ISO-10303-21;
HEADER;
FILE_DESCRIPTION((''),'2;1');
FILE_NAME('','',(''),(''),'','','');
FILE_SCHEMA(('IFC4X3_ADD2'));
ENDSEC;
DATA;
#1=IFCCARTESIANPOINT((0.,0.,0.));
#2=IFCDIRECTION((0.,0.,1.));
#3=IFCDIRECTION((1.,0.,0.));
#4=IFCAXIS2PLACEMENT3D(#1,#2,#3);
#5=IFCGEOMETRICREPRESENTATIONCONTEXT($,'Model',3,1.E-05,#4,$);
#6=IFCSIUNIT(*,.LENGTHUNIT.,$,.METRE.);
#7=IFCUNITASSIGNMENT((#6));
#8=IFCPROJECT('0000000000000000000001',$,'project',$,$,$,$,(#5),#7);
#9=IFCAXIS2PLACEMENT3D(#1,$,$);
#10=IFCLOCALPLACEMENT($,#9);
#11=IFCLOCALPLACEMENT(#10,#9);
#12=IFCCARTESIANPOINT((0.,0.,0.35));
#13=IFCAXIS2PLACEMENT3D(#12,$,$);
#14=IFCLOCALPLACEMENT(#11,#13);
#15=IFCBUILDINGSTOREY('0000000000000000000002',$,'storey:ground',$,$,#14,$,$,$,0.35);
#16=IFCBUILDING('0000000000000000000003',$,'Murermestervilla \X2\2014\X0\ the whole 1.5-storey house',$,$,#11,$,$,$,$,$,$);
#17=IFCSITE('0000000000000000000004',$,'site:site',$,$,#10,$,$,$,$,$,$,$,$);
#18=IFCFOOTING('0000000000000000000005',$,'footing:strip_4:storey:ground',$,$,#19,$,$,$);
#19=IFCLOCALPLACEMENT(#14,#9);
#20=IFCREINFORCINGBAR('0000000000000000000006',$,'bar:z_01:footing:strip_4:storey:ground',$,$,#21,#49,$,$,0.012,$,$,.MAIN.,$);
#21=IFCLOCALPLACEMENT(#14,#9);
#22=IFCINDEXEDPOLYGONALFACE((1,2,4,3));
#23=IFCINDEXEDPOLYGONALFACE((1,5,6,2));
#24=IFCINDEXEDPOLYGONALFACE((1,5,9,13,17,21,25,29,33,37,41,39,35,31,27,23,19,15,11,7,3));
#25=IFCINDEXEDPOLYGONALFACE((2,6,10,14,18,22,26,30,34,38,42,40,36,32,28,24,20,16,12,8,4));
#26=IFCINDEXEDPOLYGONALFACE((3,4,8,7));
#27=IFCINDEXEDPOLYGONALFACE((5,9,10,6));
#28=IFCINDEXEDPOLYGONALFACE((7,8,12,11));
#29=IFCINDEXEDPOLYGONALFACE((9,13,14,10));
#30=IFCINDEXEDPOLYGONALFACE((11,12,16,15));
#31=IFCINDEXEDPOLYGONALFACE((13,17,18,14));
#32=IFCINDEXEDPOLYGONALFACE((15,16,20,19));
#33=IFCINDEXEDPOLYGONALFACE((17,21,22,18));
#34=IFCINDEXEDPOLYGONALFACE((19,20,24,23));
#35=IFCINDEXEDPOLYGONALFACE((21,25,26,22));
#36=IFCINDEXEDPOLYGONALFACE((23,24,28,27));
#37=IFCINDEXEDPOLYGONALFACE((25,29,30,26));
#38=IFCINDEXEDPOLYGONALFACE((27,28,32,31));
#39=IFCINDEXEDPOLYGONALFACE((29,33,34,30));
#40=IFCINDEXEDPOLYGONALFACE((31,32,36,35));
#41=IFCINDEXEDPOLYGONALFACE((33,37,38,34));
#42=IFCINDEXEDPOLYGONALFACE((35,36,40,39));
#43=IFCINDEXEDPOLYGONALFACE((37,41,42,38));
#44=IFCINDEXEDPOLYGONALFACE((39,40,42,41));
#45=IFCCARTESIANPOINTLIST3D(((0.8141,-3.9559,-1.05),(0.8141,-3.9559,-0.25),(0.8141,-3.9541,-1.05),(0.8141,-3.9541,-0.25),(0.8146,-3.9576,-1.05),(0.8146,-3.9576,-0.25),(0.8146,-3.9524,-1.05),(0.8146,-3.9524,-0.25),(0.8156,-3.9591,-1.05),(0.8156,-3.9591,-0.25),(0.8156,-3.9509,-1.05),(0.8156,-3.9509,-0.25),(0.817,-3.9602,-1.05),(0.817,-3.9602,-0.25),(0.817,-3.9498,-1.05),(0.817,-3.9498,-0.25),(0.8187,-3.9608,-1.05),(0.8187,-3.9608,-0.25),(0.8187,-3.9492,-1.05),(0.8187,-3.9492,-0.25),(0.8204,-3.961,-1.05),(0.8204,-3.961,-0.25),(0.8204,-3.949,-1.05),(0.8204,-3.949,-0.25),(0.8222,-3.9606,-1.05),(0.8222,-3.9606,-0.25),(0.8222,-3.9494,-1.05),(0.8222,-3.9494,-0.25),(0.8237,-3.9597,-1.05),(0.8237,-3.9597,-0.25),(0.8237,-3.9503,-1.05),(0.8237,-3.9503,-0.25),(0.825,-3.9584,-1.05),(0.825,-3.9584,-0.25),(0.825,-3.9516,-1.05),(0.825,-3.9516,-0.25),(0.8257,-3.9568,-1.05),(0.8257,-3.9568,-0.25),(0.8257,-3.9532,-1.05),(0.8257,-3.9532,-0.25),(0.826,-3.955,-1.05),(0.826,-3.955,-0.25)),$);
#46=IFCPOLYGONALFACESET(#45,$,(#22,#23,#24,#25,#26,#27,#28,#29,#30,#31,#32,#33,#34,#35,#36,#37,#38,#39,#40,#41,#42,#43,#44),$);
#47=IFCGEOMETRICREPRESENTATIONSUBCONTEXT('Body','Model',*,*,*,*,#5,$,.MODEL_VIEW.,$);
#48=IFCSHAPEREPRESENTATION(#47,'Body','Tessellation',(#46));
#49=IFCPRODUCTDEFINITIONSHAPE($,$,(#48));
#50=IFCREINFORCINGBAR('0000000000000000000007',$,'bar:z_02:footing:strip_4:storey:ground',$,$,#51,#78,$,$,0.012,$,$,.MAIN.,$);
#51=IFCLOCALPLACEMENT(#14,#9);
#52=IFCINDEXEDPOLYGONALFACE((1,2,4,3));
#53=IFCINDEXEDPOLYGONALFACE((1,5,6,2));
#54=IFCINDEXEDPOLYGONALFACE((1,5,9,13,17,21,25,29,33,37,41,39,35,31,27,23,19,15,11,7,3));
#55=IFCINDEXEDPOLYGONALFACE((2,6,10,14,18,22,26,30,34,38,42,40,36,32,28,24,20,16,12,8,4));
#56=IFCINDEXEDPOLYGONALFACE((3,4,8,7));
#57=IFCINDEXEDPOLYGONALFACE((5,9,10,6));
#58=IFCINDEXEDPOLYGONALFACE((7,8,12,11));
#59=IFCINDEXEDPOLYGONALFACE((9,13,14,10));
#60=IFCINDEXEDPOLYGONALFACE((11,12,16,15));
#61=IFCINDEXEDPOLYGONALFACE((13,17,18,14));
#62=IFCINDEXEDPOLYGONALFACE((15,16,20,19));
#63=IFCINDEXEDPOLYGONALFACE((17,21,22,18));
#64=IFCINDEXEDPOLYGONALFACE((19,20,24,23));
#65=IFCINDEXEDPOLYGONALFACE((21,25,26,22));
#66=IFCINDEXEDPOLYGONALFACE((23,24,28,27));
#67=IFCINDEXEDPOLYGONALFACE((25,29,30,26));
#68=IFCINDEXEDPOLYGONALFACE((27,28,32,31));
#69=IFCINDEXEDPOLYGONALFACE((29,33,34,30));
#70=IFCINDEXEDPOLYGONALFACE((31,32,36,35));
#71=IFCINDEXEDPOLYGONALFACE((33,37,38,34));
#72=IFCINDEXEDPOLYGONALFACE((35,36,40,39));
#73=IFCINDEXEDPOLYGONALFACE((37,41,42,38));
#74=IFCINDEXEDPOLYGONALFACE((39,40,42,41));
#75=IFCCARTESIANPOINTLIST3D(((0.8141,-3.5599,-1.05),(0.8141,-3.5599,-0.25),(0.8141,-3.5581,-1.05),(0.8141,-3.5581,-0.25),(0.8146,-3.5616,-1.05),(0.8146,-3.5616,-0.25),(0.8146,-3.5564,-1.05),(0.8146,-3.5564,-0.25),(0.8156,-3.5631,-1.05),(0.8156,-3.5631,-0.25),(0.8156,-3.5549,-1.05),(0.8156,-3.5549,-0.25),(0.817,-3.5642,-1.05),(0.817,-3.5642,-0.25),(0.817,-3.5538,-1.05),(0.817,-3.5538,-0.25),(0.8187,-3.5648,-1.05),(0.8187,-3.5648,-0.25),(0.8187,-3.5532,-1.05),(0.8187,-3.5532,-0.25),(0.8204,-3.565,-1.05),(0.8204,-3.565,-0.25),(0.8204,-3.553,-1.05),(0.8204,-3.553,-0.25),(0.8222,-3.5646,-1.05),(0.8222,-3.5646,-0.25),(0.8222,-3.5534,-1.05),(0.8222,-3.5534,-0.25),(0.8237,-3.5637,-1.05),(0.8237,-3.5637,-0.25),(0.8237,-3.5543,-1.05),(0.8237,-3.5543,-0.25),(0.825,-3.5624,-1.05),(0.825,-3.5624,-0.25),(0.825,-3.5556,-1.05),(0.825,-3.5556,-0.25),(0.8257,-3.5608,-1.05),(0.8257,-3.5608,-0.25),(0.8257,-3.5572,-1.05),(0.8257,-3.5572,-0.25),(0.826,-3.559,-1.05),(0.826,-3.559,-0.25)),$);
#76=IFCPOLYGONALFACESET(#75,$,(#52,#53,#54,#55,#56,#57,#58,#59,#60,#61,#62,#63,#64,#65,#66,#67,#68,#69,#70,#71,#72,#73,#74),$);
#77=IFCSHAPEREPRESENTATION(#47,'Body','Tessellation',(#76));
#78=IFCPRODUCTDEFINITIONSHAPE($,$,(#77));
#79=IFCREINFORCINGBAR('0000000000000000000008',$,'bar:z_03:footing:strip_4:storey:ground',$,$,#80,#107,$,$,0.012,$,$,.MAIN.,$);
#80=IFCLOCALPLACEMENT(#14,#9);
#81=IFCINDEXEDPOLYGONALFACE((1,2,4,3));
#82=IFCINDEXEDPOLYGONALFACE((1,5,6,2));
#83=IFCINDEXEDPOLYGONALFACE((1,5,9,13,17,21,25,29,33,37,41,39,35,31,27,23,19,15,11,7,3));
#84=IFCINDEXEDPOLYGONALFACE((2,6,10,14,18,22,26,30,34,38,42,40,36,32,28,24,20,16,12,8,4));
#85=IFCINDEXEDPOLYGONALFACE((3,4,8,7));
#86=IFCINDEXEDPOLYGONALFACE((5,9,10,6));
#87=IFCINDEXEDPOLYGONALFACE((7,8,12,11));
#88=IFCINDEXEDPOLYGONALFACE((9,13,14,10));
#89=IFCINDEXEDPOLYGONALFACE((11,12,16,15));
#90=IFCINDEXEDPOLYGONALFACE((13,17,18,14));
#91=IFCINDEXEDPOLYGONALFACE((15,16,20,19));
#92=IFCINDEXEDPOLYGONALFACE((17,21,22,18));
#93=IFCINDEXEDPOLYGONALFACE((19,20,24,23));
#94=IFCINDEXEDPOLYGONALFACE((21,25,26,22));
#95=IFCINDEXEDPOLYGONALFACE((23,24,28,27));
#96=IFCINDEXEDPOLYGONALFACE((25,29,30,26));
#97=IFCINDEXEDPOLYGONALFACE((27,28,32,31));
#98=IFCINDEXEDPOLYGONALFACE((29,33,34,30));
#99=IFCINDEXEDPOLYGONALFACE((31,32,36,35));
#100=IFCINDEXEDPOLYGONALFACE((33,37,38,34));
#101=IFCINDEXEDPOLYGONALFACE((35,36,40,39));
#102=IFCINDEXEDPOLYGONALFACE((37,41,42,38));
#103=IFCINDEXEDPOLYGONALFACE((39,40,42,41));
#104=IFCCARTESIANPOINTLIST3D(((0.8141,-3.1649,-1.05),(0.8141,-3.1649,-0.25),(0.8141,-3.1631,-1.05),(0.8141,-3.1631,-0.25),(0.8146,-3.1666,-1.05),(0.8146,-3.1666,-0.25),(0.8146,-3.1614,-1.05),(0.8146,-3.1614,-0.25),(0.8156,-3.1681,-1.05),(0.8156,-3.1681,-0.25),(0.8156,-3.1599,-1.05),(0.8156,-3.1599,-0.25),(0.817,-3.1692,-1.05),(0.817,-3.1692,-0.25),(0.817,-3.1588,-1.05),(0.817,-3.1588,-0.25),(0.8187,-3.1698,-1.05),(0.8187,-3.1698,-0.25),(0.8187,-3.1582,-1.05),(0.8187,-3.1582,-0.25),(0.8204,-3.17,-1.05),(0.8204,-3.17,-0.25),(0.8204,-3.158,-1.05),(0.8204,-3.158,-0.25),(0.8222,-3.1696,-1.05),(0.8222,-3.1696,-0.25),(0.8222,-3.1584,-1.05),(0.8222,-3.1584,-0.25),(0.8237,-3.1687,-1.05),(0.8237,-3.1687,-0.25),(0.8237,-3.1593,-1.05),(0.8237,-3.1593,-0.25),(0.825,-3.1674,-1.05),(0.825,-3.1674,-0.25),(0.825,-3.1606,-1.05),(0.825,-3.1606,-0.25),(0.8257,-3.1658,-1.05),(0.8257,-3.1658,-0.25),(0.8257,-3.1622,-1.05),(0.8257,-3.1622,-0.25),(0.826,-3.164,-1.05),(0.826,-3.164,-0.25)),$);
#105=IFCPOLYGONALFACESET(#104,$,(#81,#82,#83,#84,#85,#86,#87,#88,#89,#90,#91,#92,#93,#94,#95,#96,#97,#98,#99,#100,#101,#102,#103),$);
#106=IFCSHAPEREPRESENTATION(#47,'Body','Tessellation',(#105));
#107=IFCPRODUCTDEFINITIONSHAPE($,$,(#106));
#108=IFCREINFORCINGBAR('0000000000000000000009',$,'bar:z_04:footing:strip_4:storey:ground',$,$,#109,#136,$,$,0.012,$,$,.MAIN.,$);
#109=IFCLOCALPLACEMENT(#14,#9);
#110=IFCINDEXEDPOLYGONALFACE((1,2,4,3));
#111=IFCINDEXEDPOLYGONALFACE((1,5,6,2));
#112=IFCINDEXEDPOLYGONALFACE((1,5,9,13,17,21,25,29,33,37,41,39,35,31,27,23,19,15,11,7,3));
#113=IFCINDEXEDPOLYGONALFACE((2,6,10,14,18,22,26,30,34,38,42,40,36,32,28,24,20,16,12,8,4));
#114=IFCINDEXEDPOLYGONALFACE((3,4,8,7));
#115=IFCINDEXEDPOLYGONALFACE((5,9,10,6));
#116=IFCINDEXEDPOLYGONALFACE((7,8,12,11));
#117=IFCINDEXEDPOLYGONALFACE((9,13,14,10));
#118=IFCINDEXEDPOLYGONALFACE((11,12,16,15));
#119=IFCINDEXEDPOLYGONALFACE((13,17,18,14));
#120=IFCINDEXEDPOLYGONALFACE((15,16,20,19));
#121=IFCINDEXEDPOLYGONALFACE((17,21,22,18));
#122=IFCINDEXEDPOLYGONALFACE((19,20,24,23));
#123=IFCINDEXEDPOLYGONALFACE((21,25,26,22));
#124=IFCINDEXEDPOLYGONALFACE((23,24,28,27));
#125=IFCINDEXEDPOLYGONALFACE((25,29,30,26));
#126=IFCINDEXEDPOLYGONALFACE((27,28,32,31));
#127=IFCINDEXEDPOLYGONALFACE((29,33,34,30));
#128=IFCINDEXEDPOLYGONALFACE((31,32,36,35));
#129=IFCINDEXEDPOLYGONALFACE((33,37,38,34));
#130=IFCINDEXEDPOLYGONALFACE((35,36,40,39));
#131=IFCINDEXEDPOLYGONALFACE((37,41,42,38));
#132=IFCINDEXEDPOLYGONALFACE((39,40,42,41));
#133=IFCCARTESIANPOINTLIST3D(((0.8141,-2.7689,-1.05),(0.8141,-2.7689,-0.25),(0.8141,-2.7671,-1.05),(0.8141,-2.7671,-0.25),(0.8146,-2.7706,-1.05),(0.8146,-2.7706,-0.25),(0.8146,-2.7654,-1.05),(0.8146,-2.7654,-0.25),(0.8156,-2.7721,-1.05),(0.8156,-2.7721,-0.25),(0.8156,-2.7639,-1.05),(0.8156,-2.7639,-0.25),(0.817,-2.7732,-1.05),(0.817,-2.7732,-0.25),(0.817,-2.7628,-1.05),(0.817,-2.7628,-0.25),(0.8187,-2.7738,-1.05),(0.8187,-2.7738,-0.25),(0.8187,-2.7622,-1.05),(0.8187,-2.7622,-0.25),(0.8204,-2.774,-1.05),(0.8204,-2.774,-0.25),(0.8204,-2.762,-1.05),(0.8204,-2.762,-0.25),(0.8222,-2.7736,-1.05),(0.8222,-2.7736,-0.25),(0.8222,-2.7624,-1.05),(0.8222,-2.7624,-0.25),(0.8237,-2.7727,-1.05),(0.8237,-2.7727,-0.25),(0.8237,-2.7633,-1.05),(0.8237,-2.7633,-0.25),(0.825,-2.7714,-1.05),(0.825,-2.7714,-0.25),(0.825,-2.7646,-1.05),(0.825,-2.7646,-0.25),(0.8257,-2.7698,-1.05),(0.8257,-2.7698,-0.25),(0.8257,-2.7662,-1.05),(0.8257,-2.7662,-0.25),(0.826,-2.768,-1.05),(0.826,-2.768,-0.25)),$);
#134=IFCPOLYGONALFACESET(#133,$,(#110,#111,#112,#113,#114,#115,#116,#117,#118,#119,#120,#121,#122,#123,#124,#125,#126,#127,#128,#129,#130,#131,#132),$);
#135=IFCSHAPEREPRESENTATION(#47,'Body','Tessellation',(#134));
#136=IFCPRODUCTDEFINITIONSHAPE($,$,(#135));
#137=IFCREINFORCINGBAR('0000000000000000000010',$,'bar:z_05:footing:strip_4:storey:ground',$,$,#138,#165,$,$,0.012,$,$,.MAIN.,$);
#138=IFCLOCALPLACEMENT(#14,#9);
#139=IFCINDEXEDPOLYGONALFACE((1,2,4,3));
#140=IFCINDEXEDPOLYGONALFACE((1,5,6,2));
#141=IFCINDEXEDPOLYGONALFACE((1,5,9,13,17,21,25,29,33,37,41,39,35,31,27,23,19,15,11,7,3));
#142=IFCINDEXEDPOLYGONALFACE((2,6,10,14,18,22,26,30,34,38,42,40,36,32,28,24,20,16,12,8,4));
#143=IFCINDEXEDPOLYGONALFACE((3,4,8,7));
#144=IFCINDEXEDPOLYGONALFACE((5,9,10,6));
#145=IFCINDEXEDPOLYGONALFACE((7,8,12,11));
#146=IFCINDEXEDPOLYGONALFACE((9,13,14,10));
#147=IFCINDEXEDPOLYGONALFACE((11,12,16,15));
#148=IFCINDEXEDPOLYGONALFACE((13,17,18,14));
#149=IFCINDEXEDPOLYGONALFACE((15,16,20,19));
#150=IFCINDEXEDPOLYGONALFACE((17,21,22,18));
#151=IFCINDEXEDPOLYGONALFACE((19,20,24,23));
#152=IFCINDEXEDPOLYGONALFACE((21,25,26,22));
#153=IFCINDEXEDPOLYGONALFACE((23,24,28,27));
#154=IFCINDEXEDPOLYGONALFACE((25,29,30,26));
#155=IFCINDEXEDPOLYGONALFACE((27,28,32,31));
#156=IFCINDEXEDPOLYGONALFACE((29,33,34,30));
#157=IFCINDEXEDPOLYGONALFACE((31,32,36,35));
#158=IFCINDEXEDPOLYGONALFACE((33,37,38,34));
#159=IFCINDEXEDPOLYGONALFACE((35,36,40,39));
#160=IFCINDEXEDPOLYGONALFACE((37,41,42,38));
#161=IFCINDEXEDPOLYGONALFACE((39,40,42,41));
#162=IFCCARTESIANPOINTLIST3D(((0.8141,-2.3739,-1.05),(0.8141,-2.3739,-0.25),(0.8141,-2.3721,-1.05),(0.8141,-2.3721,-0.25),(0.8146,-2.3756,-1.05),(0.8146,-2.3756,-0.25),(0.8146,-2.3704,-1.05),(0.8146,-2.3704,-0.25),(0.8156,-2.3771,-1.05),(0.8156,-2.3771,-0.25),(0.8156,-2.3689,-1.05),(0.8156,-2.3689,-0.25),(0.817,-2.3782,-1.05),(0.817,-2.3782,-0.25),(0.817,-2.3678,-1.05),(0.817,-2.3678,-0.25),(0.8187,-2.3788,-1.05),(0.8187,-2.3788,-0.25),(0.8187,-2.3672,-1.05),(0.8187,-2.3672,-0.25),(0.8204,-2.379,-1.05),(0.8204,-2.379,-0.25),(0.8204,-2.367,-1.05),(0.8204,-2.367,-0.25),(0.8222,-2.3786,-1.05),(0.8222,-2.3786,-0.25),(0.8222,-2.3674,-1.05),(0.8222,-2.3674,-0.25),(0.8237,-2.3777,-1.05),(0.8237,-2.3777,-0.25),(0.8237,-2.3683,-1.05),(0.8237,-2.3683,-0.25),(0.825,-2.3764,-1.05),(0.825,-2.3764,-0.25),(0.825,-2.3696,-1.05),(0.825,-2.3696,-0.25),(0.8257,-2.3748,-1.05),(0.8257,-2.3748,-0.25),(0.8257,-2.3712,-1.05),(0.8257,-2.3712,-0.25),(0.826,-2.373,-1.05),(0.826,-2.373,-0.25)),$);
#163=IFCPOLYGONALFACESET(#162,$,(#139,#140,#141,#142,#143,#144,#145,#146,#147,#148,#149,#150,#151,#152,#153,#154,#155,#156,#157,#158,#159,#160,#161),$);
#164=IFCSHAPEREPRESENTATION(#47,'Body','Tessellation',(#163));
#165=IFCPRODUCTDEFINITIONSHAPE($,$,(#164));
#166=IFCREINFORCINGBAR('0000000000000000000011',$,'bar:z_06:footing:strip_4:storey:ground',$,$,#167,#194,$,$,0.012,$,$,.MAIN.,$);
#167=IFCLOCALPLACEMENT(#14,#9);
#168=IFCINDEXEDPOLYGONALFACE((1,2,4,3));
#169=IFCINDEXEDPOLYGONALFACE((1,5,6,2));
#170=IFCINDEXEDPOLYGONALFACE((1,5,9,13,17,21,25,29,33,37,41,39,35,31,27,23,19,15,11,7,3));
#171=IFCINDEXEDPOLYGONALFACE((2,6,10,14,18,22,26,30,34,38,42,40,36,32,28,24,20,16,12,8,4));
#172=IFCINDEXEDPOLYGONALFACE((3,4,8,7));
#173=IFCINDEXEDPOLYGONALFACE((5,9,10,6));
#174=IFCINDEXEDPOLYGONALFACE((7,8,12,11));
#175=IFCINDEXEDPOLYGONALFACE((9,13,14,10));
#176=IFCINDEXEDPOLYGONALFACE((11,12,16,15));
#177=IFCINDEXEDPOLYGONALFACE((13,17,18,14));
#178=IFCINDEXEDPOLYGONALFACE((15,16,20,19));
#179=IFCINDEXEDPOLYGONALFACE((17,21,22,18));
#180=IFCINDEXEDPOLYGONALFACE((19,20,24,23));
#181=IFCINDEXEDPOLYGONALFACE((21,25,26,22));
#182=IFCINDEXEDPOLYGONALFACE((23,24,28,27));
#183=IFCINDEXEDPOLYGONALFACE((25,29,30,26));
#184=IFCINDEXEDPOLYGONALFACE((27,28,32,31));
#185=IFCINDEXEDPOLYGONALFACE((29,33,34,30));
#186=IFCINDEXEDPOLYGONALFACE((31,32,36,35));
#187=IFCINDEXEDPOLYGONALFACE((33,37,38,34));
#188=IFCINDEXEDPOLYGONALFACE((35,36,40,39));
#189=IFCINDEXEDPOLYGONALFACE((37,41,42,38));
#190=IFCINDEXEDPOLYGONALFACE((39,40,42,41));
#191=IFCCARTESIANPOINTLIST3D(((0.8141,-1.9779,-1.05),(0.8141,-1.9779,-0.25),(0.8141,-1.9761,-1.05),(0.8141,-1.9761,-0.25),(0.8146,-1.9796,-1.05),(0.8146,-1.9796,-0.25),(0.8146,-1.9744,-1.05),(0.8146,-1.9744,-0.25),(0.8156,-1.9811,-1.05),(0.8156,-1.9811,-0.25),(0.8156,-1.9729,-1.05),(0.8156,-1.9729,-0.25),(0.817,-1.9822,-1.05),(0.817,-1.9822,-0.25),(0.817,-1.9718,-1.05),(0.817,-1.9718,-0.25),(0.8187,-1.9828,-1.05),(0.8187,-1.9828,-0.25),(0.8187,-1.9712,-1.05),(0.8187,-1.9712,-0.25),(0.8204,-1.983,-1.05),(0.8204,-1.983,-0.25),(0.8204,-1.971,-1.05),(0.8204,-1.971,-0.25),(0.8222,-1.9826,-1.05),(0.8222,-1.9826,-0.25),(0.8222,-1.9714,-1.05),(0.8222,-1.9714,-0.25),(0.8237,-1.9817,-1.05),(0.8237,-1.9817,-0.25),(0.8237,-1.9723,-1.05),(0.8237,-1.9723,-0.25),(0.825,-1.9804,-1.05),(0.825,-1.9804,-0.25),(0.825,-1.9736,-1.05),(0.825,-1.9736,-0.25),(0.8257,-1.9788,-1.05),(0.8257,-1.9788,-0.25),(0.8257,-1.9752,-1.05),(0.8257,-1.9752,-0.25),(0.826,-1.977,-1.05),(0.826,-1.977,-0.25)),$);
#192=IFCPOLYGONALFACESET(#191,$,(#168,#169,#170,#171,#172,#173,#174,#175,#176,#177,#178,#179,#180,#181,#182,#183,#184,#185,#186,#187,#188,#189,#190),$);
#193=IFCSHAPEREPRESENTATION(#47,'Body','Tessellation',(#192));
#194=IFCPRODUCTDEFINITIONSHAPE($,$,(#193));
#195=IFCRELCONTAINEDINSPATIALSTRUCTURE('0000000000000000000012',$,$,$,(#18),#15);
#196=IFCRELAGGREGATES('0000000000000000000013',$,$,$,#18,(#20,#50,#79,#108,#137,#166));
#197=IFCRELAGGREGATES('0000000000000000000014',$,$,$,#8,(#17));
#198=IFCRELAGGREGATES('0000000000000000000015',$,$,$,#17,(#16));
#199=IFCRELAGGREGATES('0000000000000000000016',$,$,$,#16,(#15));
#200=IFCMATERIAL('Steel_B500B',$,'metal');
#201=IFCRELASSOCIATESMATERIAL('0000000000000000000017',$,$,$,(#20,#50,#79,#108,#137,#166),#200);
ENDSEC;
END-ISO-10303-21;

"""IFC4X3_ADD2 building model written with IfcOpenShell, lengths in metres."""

from ifc_helpers import new_model, entity, si_unit, frame, origin, origin_with_axes, place, context, subcontext, project, spatial, material, element, aggregate, save


model = new_model("IFC4X3_ADD2")

# Units and contexts
model_context = context("Model", 3, precision=1e-05, world=origin_with_axes())
body_context = subcontext(model_context, "Body", "Model", "MODEL_VIEW")
ifc_project = project(units=[si_unit("LENGTHUNIT", "METRE")], contexts=[model_context])

# Site, building, storey
placement_1 = place(None, origin())
site = spatial("IfcSite", under=ifc_project, at=placement_1, Name="site:site")
building_placement = place(placement_1, origin())
building = spatial("IfcBuilding", under=site, at=building_placement, Name="Murermestervilla — the whole 1.5-storey house")
storey_placement = place(building_placement, frame((0.0, 0.0, 0.35)))
storey = spatial("IfcBuildingStorey", under=building, at=storey_placement, Name="storey:ground", Elevation=0.35)

# Footing, reinforcing bars
placement_2 = place(storey_placement, frame((0.0, 0.0, -0.35)))
ifc_material = material(Name="Steel_B500B", Category="metal")
footing_1 = element("IfcFooting", 1, at=placement_2, inside=storey, Name="footing:strip_4:storey:ground")
reinforcing_bar_1 = element("IfcReinforcingBar", 2, at=placement_1, material=ifc_material, Name="bar:z_01:footing:strip_4:storey:ground", NominalDiameter=0.012, PredefinedType="MAIN", context=body_context, shape_type="AdvancedSweptSolid", body=[
    entity("IfcSweptDiskSolid", entity("IfcPolyline", [entity("IfcCartesianPoint", [0.82, -3.955, -0.7]), entity("IfcCartesianPoint", [0.82, -3.955, 0.1])]), 0.006),
])
reinforcing_bar_2 = element("IfcReinforcingBar", 3, at=placement_1, material=ifc_material, Name="bar:z_02:footing:strip_4:storey:ground", NominalDiameter=0.012, PredefinedType="MAIN", context=body_context, shape_type="AdvancedSweptSolid", body=[
    entity("IfcSweptDiskSolid", entity("IfcPolyline", [entity("IfcCartesianPoint", [0.82, -3.559, -0.7]), entity("IfcCartesianPoint", [0.82, -3.559, 0.1])]), 0.006),
])
reinforcing_bar_3 = element("IfcReinforcingBar", 4, at=placement_1, material=ifc_material, Name="bar:z_03:footing:strip_4:storey:ground", NominalDiameter=0.012, PredefinedType="MAIN", context=body_context, shape_type="AdvancedSweptSolid", body=[
    entity("IfcSweptDiskSolid", entity("IfcPolyline", [entity("IfcCartesianPoint", [0.82, -3.164, -0.7]), entity("IfcCartesianPoint", [0.82, -3.164, 0.1])]), 0.006),
])
reinforcing_bar_4 = element("IfcReinforcingBar", 5, at=placement_1, material=ifc_material, Name="bar:z_04:footing:strip_4:storey:ground", NominalDiameter=0.012, PredefinedType="MAIN", context=body_context, shape_type="AdvancedSweptSolid", body=[
    entity("IfcSweptDiskSolid", entity("IfcPolyline", [entity("IfcCartesianPoint", [0.82, -2.768, -0.7]), entity("IfcCartesianPoint", [0.82, -2.768, 0.1])]), 0.006),
])
reinforcing_bar_5 = element("IfcReinforcingBar", 6, at=placement_1, material=ifc_material, Name="bar:z_05:footing:strip_4:storey:ground", NominalDiameter=0.012, PredefinedType="MAIN", context=body_context, shape_type="AdvancedSweptSolid", body=[
    entity("IfcSweptDiskSolid", entity("IfcPolyline", [entity("IfcCartesianPoint", [0.82, -2.373, -0.7]), entity("IfcCartesianPoint", [0.82, -2.373, 0.1])]), 0.006),
])
reinforcing_bar_6 = element("IfcReinforcingBar", 7, at=placement_1, material=ifc_material, Name="bar:z_06:footing:strip_4:storey:ground", NominalDiameter=0.012, PredefinedType="MAIN", context=body_context, shape_type="AdvancedSweptSolid", body=[
    entity("IfcSweptDiskSolid", entity("IfcPolyline", [entity("IfcCartesianPoint", [0.82, -1.977, -0.7]), entity("IfcCartesianPoint", [0.82, -1.977, 0.1])]), 0.006),
])
aggregate(footing_1, [reinforcing_bar_1, reinforcing_bar_2, reinforcing_bar_3, reinforcing_bar_4, reinforcing_bar_5, reinforcing_bar_6])

save(model, "model.ifc")
